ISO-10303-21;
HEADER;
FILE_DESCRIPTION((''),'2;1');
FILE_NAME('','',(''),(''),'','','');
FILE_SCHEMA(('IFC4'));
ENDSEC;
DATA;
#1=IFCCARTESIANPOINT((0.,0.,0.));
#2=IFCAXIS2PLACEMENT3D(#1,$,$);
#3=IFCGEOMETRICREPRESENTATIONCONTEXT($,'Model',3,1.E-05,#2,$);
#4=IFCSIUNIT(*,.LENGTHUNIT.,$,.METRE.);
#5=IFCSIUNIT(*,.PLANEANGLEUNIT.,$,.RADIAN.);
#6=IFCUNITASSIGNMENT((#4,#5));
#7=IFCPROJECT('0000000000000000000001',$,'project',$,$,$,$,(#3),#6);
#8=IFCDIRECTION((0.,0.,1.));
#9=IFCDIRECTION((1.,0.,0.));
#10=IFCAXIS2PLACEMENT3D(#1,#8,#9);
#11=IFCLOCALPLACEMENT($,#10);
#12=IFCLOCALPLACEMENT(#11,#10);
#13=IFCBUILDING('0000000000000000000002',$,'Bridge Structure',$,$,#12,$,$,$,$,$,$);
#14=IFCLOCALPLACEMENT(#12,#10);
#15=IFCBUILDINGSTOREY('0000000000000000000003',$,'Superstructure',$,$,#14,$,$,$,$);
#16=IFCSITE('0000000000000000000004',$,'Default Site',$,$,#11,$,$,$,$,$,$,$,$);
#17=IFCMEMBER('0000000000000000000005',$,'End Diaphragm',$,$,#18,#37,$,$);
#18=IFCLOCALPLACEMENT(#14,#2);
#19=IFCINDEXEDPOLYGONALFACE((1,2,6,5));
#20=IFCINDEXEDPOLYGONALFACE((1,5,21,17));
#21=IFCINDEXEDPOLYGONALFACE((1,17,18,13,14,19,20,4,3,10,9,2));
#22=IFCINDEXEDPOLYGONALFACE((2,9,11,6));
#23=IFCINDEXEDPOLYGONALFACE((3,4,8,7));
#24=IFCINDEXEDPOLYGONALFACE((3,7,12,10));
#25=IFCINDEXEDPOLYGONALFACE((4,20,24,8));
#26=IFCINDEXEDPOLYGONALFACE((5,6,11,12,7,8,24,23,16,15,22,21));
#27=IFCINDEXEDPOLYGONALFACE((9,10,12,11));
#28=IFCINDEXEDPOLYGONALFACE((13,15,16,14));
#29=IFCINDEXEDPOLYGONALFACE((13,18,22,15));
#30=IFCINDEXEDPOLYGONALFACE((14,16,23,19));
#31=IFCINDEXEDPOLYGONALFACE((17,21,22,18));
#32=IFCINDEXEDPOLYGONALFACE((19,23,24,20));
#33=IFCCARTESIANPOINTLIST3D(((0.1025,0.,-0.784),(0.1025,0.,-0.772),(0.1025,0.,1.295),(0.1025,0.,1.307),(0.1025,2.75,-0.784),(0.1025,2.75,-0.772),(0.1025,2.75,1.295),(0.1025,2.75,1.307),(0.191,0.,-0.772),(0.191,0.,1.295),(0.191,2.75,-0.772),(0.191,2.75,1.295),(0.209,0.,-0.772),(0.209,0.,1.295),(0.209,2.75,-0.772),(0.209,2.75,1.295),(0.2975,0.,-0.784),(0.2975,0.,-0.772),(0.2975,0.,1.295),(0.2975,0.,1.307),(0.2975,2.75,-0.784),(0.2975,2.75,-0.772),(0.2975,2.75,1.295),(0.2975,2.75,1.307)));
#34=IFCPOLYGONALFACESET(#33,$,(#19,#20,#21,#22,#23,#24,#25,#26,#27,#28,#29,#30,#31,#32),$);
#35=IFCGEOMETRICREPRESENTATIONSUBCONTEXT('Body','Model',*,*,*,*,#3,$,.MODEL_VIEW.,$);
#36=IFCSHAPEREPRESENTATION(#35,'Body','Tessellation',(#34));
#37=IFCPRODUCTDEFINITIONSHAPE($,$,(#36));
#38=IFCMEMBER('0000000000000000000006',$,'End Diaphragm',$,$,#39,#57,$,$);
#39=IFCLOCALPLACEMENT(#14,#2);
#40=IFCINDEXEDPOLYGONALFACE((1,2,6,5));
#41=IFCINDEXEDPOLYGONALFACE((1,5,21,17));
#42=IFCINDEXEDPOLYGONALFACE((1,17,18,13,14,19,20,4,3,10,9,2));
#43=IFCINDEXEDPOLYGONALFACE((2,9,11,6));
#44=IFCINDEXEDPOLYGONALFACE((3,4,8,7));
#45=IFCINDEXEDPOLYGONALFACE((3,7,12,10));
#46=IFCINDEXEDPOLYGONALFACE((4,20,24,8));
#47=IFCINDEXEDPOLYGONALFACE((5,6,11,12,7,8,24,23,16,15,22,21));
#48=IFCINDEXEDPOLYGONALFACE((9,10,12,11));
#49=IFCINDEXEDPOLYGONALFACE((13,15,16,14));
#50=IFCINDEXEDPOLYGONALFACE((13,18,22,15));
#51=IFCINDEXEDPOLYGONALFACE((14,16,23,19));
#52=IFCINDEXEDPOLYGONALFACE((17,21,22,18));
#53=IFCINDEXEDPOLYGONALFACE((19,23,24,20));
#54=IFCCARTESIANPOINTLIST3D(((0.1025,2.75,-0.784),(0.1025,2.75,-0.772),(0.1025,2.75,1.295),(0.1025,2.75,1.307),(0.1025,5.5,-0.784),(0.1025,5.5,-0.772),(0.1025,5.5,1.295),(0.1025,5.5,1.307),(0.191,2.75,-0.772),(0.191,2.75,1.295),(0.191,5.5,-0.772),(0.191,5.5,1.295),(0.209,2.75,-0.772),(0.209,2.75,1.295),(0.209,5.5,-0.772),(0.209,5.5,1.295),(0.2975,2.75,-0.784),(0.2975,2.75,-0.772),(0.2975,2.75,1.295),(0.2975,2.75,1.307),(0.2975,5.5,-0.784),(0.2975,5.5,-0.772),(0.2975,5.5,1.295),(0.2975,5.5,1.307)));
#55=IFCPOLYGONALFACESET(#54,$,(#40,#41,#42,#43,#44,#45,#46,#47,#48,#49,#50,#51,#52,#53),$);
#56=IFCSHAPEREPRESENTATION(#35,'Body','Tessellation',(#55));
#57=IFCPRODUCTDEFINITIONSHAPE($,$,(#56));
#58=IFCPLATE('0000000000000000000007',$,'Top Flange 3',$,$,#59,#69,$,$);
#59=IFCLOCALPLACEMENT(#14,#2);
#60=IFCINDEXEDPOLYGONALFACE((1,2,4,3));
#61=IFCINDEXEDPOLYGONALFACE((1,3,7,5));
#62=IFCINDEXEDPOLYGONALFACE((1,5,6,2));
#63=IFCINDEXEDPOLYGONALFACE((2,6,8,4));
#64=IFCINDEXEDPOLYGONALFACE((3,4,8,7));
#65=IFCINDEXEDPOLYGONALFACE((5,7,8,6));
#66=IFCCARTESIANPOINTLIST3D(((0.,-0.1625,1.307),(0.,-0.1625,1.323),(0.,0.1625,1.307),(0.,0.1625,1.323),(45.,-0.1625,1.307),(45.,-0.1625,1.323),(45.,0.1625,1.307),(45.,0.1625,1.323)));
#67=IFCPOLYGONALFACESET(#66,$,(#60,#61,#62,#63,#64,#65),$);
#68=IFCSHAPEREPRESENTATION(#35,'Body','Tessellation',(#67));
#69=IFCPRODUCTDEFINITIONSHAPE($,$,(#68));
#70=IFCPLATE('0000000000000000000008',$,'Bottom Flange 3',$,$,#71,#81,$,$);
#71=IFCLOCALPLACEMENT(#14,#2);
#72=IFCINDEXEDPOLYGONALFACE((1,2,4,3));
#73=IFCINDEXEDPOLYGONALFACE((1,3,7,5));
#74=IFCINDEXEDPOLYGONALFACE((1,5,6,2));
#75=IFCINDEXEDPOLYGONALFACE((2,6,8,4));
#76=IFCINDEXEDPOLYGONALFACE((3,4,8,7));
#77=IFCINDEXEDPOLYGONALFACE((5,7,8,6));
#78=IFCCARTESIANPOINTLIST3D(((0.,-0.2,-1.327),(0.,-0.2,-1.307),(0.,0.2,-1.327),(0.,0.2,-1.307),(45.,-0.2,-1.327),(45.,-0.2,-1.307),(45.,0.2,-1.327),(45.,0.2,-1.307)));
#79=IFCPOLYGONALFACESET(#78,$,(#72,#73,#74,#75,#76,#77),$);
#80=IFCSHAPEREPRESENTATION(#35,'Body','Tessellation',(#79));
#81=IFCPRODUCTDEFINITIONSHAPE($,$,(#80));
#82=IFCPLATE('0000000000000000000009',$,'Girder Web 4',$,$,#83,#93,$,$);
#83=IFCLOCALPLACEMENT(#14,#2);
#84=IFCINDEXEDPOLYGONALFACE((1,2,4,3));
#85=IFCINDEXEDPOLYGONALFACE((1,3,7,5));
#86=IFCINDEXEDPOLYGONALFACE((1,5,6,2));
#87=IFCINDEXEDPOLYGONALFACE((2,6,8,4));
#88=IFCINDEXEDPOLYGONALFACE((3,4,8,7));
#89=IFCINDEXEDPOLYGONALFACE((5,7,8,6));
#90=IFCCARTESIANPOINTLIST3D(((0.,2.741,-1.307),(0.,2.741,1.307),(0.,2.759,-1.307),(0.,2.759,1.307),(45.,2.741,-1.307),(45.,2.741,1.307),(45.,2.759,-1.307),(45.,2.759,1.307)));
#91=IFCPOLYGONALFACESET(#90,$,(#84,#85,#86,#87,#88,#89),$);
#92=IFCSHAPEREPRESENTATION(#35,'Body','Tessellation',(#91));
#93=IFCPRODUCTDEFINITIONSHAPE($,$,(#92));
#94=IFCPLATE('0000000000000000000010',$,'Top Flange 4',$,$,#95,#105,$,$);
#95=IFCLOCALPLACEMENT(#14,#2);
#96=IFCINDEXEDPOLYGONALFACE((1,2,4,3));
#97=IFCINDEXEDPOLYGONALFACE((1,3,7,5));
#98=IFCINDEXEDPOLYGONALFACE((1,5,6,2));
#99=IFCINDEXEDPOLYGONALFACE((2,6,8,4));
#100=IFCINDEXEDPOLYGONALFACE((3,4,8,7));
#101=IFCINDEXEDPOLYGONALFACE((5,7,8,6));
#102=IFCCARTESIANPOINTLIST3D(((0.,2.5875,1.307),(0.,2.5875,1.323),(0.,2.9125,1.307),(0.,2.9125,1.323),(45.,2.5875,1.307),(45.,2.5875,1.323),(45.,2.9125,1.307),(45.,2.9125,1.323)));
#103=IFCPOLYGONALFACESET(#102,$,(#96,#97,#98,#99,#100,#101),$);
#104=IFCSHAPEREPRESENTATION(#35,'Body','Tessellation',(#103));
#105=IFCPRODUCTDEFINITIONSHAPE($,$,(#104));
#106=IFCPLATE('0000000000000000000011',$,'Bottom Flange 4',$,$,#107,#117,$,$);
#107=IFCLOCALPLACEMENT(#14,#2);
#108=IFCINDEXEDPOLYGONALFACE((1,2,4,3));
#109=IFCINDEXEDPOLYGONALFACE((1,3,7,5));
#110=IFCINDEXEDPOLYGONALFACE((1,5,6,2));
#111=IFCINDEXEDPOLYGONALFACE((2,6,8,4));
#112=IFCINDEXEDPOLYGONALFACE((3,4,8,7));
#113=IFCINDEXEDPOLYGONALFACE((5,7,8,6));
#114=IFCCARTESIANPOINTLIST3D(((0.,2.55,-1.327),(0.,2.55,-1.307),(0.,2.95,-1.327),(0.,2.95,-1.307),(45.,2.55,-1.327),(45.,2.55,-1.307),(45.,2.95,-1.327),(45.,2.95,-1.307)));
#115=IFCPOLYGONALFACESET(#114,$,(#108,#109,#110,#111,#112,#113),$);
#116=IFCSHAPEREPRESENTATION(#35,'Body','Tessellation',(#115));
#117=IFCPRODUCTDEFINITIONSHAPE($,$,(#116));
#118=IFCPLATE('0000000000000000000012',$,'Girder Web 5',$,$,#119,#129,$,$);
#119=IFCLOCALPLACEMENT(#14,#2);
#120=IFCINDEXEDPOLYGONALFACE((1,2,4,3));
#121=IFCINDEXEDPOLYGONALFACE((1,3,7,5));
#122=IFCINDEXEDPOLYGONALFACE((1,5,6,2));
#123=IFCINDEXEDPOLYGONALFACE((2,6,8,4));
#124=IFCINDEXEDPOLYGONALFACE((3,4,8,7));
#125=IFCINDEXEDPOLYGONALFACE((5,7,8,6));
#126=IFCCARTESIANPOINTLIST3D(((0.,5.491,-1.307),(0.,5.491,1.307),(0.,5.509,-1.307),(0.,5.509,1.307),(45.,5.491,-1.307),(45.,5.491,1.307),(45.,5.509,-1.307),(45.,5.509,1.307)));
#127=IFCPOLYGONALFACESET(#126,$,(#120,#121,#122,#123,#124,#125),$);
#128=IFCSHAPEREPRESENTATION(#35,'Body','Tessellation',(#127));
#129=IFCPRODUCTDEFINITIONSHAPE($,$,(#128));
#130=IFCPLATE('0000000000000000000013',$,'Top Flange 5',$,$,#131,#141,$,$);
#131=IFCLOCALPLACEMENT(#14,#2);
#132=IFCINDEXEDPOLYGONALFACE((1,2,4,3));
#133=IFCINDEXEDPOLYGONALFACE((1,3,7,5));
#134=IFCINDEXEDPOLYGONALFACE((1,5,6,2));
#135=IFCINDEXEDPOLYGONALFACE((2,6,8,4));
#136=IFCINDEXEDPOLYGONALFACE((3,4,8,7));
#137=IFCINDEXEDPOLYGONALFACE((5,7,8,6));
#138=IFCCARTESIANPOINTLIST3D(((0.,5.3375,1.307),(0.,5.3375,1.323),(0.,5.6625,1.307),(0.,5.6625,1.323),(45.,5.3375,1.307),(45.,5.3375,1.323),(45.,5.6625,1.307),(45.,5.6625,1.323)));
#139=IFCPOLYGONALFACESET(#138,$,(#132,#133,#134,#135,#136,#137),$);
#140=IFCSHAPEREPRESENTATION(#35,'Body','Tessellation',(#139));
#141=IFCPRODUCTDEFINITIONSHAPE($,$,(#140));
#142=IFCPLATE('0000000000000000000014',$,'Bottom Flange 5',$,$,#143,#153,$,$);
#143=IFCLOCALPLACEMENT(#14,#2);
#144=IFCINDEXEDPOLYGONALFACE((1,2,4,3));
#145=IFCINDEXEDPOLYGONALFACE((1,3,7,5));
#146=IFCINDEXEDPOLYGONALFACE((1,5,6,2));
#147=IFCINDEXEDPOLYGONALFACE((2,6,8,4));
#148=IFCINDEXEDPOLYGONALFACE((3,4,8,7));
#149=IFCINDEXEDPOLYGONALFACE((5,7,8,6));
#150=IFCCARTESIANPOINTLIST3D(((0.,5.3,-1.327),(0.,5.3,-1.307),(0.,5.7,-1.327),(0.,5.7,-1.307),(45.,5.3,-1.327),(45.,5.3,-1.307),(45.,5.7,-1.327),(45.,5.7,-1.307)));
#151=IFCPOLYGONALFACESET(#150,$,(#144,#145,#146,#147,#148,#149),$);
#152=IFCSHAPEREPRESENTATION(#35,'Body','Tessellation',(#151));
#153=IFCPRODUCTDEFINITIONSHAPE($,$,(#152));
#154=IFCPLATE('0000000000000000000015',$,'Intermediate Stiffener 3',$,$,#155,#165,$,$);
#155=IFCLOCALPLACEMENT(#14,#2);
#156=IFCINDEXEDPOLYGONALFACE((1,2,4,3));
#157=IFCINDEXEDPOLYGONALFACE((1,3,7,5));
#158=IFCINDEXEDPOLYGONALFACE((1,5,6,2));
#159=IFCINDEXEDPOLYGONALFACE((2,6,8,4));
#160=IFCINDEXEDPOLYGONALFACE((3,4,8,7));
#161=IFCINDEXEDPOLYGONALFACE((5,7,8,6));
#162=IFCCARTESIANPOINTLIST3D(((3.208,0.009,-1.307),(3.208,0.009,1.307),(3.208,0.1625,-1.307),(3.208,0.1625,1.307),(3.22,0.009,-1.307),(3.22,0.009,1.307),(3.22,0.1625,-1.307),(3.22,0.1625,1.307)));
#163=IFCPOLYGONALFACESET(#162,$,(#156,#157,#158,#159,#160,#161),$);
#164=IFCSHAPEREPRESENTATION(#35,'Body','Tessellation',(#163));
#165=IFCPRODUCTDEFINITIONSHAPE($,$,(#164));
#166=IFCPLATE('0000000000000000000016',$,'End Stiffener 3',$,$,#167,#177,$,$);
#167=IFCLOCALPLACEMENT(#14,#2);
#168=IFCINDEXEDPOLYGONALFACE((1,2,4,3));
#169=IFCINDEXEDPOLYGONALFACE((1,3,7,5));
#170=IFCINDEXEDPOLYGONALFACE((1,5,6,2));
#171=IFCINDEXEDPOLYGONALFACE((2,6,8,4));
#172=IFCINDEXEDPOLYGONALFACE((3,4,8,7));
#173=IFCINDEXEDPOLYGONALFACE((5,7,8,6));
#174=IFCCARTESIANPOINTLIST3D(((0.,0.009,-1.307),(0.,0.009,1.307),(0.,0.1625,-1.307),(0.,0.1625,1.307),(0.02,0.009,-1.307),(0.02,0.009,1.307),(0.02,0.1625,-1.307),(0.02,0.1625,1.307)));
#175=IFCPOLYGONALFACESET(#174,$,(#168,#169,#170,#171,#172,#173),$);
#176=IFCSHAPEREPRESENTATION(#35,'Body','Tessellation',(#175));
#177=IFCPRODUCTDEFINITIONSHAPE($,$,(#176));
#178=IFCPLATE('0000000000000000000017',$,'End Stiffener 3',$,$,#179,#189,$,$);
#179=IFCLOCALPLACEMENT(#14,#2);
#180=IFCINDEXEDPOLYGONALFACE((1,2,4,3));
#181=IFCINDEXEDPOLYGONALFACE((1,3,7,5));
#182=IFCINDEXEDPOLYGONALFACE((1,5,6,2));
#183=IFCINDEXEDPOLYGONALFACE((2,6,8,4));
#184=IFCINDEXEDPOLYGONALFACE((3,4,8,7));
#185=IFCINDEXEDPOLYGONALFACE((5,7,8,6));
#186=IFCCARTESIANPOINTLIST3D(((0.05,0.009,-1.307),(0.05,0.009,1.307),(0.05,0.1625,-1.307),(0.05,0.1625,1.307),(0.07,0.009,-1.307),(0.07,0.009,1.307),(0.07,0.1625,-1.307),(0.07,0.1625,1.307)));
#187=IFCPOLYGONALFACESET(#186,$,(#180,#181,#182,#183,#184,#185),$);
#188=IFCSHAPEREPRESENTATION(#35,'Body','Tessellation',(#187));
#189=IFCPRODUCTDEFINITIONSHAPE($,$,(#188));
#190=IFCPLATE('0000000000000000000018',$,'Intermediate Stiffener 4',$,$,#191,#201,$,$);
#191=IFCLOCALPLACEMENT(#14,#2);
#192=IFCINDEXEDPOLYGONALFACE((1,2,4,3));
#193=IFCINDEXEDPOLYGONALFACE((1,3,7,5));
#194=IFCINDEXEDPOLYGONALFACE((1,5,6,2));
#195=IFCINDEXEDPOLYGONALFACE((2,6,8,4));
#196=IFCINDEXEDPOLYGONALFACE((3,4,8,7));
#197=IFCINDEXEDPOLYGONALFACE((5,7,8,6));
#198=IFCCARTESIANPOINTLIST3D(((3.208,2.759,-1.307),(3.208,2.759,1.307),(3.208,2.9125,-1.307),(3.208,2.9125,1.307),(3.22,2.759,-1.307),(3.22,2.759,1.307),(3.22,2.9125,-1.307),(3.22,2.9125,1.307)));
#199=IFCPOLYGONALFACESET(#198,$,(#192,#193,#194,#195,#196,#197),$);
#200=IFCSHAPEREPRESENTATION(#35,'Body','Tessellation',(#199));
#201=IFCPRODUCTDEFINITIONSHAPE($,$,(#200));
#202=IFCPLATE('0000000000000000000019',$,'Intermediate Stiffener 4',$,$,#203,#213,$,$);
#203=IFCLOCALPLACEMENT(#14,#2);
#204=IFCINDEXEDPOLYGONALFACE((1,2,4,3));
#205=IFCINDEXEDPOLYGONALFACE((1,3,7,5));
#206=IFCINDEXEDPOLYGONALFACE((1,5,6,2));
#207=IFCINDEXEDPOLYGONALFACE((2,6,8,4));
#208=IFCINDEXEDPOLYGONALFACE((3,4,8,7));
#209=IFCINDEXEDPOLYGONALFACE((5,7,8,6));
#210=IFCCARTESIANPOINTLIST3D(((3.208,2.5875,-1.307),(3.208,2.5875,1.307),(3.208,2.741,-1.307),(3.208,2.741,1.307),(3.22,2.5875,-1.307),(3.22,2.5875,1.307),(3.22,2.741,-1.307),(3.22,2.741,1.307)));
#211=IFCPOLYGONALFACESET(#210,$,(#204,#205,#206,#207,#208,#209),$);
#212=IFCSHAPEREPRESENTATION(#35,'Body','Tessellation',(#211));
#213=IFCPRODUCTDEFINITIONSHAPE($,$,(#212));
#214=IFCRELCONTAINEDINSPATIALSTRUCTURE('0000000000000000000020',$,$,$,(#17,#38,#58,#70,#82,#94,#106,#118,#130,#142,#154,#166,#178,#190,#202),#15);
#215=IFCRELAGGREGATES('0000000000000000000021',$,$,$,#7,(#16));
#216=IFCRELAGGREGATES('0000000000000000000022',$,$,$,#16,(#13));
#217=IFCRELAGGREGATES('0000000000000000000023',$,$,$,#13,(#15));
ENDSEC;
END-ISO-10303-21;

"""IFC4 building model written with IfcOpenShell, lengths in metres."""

from ifc_helpers import new_model, si_unit, frame, origin, origin_with_axes, origin_2d_with_axis, place, context, subcontext, project, spatial, rectangle, i_section, extrude, element, save


model = new_model("IFC4")

# Units and contexts
model_context = context("Model", 3, precision=1e-05, world=origin())
body_context = subcontext(model_context, "Body", "Model", "MODEL_VIEW")
ifc_project = project(units=[si_unit("LENGTHUNIT", "METRE"), si_unit("PLANEANGLEUNIT", "RADIAN")], contexts=[model_context])

# Site, building, storey
site_placement = place(None, origin_with_axes())
site = spatial("IfcSite", under=ifc_project, at=site_placement, Name="Default Site")
building_placement = place(site_placement, origin_with_axes())
building = spatial("IfcBuilding", under=site, at=building_placement, Name="Bridge Structure")
storey_placement = place(building_placement, origin_with_axes())
storey = spatial("IfcBuildingStorey", under=building, at=storey_placement, Name="Superstructure")

# Members
for number, where, z_axis, x_axis, name in (
    (1, (0.2, 0.0, 0.2615), (0.0, 1.0, 0.0), (-1.0, 0.0, 0.0), "End Diaphragm"),
    (2, (0.2, 2.75, 0.2615), (0.0, 1.0, 0.0), (-1.0, 0.0, 0.0), "End Diaphragm"),
):
    element("IfcMember", number, at=place(storey_placement, frame(where, z_axis=z_axis, x_axis=x_axis)), inside=storey, Name=name, context=body_context, shape_type="SweptSolid", body=[
        extrude(i_section(OverallWidth=0.195, OverallDepth=2.091, WebThickness=0.018, FlangeThickness=0.012, at=origin_2d_with_axis()), origin_with_axes(), (0.0, 0.0, 1.0), 2.75),
    ])

# Plates
plate_1_placement = place(storey_placement, frame((0.0, 0.0, 1.315), z_axis=(1.0, 0.0, 0.0), x_axis=(0.0, 1.0, 0.0)))
element("IfcPlate", 3, at=plate_1_placement, inside=storey, Name="Top Flange 3", context=body_context, shape_type="SweptSolid", body=[
    extrude(rectangle(XDim=0.325, YDim=0.016, at=origin_2d_with_axis()), origin_with_axes(), (0.0, 0.0, 1.0), 45.0),
])
plate_2_placement = place(storey_placement, frame((0.0, 0.0, -1.317), z_axis=(1.0, 0.0, 0.0), x_axis=(0.0, 1.0, 0.0)))
element("IfcPlate", 4, at=plate_2_placement, inside=storey, Name="Bottom Flange 3", context=body_context, shape_type="SweptSolid", body=[
    extrude(rectangle(XDim=0.4, YDim=0.02, at=origin_2d_with_axis()), origin_with_axes(), (0.0, 0.0, 1.0), 45.0),
])
plate_3_placement = place(storey_placement, frame((0.0, 2.75, 0.0), z_axis=(1.0, 0.0, 0.0), x_axis=(0.0, 1.0, 0.0)))
element("IfcPlate", 5, at=plate_3_placement, inside=storey, Name="Girder Web 4", context=body_context, shape_type="SweptSolid", body=[
    extrude(rectangle(XDim=0.018, YDim=2.614, at=origin_2d_with_axis()), origin_with_axes(), (0.0, 0.0, 1.0), 45.0),
])
plate_4_placement = place(storey_placement, frame((0.0, 2.75, 1.315), z_axis=(1.0, 0.0, 0.0), x_axis=(0.0, 1.0, 0.0)))
element("IfcPlate", 6, at=plate_4_placement, inside=storey, Name="Top Flange 4", context=body_context, shape_type="SweptSolid", body=[
    extrude(rectangle(XDim=0.325, YDim=0.016, at=origin_2d_with_axis()), origin_with_axes(), (0.0, 0.0, 1.0), 45.0),
])
plate_5_placement = place(storey_placement, frame((0.0, 2.75, -1.317), z_axis=(1.0, 0.0, 0.0), x_axis=(0.0, 1.0, 0.0)))
element("IfcPlate", 7, at=plate_5_placement, inside=storey, Name="Bottom Flange 4", context=body_context, shape_type="SweptSolid", body=[
    extrude(rectangle(XDim=0.4, YDim=0.02, at=origin_2d_with_axis()), origin_with_axes(), (0.0, 0.0, 1.0), 45.0),
])
plate_6_placement = place(storey_placement, frame((0.0, 5.5, 0.0), z_axis=(1.0, 0.0, 0.0), x_axis=(0.0, 1.0, 0.0)))
element("IfcPlate", 8, at=plate_6_placement, inside=storey, Name="Girder Web 5", context=body_context, shape_type="SweptSolid", body=[
    extrude(rectangle(XDim=0.018, YDim=2.614, at=origin_2d_with_axis()), origin_with_axes(), (0.0, 0.0, 1.0), 45.0),
])
plate_7_placement = place(storey_placement, frame((0.0, 5.5, 1.315), z_axis=(1.0, 0.0, 0.0), x_axis=(0.0, 1.0, 0.0)))
element("IfcPlate", 9, at=plate_7_placement, inside=storey, Name="Top Flange 5", context=body_context, shape_type="SweptSolid", body=[
    extrude(rectangle(XDim=0.325, YDim=0.016, at=origin_2d_with_axis()), origin_with_axes(), (0.0, 0.0, 1.0), 45.0),
])
plate_8_placement = place(storey_placement, frame((0.0, 5.5, -1.317), z_axis=(1.0, 0.0, 0.0), x_axis=(0.0, 1.0, 0.0)))
element("IfcPlate", 10, at=plate_8_placement, inside=storey, Name="Bottom Flange 5", context=body_context, shape_type="SweptSolid", body=[
    extrude(rectangle(XDim=0.4, YDim=0.02, at=origin_2d_with_axis()), origin_with_axes(), (0.0, 0.0, 1.0), 45.0),
])
plate_9_placement = place(storey_placement, frame((3.214, 0.0858, -1.307), z_axis=(0.0, 0.0, 1.0), x_axis=(1.0, 0.0, 0.0)))
element("IfcPlate", 11, at=plate_9_placement, inside=storey, Name="Intermediate Stiffener 3", context=body_context, shape_type="SweptSolid", body=[
    extrude(rectangle(XDim=0.012, YDim=0.1535, at=origin_2d_with_axis()), origin_with_axes(), (0.0, 0.0, 1.0), 2.614),
])
for number, where, z_axis, x_axis, name in (
    (12, (0.01, 0.0858, -1.307), (0.0, 0.0, 1.0), (1.0, 0.0, 0.0), "End Stiffener 3"),
    (13, (0.06, 0.0858, -1.307), (0.0, 0.0, 1.0), (1.0, 0.0, 0.0), "End Stiffener 3"),
):
    element("IfcPlate", number, at=place(storey_placement, frame(where, z_axis=z_axis, x_axis=x_axis)), inside=storey, Name=name, context=body_context, shape_type="SweptSolid", body=[
        extrude(rectangle(XDim=0.02, YDim=0.1535, at=origin_2d_with_axis()), origin_with_axes(), (0.0, 0.0, 1.0), 2.614),
    ])
for number, where, z_axis, x_axis, name in (
    (14, (3.214, 2.8357, -1.307), (0.0, 0.0, 1.0), (1.0, 0.0, 0.0), "Intermediate Stiffener 4"),
    (15, (3.214, 2.6643, -1.307), (0.0, 0.0, 1.0), (1.0, 0.0, 0.0), "Intermediate Stiffener 4"),
):
    element("IfcPlate", number, at=place(storey_placement, frame(where, z_axis=z_axis, x_axis=x_axis)), inside=storey, Name=name, context=body_context, shape_type="SweptSolid", body=[
        extrude(rectangle(XDim=0.012, YDim=0.1535, at=origin_2d_with_axis()), origin_with_axes(), (0.0, 0.0, 1.0), 2.614),
    ])

save(model, "model.ifc")
